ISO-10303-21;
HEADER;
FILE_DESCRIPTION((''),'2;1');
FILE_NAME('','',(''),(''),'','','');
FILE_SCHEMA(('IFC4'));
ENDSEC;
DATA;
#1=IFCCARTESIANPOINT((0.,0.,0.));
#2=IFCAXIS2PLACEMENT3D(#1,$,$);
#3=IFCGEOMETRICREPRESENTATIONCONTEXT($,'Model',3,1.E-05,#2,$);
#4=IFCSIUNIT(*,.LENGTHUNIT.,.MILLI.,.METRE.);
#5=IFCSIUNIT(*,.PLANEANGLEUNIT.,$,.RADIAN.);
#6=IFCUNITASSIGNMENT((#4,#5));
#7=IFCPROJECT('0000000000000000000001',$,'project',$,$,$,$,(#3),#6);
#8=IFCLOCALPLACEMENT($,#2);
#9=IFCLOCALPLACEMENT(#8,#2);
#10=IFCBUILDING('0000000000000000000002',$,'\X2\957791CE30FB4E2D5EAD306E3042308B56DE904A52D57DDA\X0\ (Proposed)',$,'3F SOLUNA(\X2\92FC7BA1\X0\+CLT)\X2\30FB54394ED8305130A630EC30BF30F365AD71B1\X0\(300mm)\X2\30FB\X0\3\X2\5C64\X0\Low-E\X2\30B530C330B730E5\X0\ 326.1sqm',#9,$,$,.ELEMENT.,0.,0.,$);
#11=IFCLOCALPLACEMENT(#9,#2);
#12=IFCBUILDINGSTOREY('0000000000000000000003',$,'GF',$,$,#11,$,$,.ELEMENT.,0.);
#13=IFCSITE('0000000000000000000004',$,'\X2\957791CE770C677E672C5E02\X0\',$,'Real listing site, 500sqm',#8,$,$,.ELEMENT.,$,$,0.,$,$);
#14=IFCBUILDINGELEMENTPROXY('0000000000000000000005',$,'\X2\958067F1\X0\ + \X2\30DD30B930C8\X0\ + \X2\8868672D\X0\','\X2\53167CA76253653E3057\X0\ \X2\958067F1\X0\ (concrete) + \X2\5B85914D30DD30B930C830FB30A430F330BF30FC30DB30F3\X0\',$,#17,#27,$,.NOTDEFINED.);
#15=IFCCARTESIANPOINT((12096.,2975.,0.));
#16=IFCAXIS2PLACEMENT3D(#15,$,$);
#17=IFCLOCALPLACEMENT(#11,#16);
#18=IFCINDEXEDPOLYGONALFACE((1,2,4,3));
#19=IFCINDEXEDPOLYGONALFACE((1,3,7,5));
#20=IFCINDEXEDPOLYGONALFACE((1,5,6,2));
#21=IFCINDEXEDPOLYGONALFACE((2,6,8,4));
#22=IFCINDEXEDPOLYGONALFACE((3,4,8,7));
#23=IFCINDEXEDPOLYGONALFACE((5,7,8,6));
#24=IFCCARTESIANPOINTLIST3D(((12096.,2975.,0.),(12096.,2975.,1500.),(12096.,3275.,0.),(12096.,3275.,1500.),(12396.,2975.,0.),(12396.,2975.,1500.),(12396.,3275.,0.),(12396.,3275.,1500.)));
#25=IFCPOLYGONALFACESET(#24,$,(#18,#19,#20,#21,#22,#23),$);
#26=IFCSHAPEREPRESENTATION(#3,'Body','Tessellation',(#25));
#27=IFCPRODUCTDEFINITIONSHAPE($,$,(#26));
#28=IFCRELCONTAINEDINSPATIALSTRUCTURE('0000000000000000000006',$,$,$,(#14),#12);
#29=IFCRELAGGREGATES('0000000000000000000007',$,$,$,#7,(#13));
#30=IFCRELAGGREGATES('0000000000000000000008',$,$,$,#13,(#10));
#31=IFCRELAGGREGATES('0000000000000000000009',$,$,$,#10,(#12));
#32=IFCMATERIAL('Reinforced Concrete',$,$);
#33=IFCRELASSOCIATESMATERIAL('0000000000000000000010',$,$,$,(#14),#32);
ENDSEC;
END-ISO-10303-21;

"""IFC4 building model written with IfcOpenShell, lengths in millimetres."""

from ifc_helpers import new_model, si_unit, frame, frame_2d, origin, place, context, project, spatial, rectangle, extrude, material, element, save


model = new_model("IFC4")

# Units and contexts
model_context = context("Model", 3, precision=1e-05, world=origin())
ifc_project = project(units=[si_unit("LENGTHUNIT", "METRE", prefix="MILLI"), si_unit("PLANEANGLEUNIT", "RADIAN")], contexts=[model_context])

# Site, building, storey
site_placement = place(None, origin())
site = spatial("IfcSite", under=ifc_project, at=site_placement, Name="長野県松本市", ObjectType="Real listing site, 500sqm", CompositionType="ELEMENT", RefElevation=0.0)
building_placement = place(site_placement, origin())
building = spatial("IfcBuilding", under=site, at=building_placement, Name="長野・中庭のある回遊動線 (Proposed)", ObjectType="3F SOLUNA(鋼管+CLT)・吹付けウレタン断熱(300mm)・3層Low-Eサッシュ 326.1sqm", CompositionType="ELEMENT", ElevationOfRefHeight=0.0, ElevationOfTerrain=0.0)
storey_placement = place(building_placement, origin())
storey = spatial("IfcBuildingStorey", under=building, at=storey_placement, Name="GF", CompositionType="ELEMENT", Elevation=0.0)

# Shared definitions
ifc_material_1 = material(Name="Reinforced Concrete")

# Building element proxy
proxy_placement = place(storey_placement, frame((12096.0, 2975.0, 0.0)))
element("IfcBuildingElementProxy", 1, at=proxy_placement, inside=storey, material=ifc_material_1, Name="門柱 + ポスト + 表札", Description="化粧打放し 門柱 (concrete) + 宅配ポスト・インターホン", PredefinedType="NOTDEFINED", context=model_context, shape_type="SweptSolid", body=[
    extrude(rectangle(XDim=300.0, YDim=300.0, at=frame_2d((150.0, 150.0))), frame((12096.0, 2975.0, 0.0)), (0.0, 0.0, 1.0), 1500.0),
])

save(model, "model.ifc")
